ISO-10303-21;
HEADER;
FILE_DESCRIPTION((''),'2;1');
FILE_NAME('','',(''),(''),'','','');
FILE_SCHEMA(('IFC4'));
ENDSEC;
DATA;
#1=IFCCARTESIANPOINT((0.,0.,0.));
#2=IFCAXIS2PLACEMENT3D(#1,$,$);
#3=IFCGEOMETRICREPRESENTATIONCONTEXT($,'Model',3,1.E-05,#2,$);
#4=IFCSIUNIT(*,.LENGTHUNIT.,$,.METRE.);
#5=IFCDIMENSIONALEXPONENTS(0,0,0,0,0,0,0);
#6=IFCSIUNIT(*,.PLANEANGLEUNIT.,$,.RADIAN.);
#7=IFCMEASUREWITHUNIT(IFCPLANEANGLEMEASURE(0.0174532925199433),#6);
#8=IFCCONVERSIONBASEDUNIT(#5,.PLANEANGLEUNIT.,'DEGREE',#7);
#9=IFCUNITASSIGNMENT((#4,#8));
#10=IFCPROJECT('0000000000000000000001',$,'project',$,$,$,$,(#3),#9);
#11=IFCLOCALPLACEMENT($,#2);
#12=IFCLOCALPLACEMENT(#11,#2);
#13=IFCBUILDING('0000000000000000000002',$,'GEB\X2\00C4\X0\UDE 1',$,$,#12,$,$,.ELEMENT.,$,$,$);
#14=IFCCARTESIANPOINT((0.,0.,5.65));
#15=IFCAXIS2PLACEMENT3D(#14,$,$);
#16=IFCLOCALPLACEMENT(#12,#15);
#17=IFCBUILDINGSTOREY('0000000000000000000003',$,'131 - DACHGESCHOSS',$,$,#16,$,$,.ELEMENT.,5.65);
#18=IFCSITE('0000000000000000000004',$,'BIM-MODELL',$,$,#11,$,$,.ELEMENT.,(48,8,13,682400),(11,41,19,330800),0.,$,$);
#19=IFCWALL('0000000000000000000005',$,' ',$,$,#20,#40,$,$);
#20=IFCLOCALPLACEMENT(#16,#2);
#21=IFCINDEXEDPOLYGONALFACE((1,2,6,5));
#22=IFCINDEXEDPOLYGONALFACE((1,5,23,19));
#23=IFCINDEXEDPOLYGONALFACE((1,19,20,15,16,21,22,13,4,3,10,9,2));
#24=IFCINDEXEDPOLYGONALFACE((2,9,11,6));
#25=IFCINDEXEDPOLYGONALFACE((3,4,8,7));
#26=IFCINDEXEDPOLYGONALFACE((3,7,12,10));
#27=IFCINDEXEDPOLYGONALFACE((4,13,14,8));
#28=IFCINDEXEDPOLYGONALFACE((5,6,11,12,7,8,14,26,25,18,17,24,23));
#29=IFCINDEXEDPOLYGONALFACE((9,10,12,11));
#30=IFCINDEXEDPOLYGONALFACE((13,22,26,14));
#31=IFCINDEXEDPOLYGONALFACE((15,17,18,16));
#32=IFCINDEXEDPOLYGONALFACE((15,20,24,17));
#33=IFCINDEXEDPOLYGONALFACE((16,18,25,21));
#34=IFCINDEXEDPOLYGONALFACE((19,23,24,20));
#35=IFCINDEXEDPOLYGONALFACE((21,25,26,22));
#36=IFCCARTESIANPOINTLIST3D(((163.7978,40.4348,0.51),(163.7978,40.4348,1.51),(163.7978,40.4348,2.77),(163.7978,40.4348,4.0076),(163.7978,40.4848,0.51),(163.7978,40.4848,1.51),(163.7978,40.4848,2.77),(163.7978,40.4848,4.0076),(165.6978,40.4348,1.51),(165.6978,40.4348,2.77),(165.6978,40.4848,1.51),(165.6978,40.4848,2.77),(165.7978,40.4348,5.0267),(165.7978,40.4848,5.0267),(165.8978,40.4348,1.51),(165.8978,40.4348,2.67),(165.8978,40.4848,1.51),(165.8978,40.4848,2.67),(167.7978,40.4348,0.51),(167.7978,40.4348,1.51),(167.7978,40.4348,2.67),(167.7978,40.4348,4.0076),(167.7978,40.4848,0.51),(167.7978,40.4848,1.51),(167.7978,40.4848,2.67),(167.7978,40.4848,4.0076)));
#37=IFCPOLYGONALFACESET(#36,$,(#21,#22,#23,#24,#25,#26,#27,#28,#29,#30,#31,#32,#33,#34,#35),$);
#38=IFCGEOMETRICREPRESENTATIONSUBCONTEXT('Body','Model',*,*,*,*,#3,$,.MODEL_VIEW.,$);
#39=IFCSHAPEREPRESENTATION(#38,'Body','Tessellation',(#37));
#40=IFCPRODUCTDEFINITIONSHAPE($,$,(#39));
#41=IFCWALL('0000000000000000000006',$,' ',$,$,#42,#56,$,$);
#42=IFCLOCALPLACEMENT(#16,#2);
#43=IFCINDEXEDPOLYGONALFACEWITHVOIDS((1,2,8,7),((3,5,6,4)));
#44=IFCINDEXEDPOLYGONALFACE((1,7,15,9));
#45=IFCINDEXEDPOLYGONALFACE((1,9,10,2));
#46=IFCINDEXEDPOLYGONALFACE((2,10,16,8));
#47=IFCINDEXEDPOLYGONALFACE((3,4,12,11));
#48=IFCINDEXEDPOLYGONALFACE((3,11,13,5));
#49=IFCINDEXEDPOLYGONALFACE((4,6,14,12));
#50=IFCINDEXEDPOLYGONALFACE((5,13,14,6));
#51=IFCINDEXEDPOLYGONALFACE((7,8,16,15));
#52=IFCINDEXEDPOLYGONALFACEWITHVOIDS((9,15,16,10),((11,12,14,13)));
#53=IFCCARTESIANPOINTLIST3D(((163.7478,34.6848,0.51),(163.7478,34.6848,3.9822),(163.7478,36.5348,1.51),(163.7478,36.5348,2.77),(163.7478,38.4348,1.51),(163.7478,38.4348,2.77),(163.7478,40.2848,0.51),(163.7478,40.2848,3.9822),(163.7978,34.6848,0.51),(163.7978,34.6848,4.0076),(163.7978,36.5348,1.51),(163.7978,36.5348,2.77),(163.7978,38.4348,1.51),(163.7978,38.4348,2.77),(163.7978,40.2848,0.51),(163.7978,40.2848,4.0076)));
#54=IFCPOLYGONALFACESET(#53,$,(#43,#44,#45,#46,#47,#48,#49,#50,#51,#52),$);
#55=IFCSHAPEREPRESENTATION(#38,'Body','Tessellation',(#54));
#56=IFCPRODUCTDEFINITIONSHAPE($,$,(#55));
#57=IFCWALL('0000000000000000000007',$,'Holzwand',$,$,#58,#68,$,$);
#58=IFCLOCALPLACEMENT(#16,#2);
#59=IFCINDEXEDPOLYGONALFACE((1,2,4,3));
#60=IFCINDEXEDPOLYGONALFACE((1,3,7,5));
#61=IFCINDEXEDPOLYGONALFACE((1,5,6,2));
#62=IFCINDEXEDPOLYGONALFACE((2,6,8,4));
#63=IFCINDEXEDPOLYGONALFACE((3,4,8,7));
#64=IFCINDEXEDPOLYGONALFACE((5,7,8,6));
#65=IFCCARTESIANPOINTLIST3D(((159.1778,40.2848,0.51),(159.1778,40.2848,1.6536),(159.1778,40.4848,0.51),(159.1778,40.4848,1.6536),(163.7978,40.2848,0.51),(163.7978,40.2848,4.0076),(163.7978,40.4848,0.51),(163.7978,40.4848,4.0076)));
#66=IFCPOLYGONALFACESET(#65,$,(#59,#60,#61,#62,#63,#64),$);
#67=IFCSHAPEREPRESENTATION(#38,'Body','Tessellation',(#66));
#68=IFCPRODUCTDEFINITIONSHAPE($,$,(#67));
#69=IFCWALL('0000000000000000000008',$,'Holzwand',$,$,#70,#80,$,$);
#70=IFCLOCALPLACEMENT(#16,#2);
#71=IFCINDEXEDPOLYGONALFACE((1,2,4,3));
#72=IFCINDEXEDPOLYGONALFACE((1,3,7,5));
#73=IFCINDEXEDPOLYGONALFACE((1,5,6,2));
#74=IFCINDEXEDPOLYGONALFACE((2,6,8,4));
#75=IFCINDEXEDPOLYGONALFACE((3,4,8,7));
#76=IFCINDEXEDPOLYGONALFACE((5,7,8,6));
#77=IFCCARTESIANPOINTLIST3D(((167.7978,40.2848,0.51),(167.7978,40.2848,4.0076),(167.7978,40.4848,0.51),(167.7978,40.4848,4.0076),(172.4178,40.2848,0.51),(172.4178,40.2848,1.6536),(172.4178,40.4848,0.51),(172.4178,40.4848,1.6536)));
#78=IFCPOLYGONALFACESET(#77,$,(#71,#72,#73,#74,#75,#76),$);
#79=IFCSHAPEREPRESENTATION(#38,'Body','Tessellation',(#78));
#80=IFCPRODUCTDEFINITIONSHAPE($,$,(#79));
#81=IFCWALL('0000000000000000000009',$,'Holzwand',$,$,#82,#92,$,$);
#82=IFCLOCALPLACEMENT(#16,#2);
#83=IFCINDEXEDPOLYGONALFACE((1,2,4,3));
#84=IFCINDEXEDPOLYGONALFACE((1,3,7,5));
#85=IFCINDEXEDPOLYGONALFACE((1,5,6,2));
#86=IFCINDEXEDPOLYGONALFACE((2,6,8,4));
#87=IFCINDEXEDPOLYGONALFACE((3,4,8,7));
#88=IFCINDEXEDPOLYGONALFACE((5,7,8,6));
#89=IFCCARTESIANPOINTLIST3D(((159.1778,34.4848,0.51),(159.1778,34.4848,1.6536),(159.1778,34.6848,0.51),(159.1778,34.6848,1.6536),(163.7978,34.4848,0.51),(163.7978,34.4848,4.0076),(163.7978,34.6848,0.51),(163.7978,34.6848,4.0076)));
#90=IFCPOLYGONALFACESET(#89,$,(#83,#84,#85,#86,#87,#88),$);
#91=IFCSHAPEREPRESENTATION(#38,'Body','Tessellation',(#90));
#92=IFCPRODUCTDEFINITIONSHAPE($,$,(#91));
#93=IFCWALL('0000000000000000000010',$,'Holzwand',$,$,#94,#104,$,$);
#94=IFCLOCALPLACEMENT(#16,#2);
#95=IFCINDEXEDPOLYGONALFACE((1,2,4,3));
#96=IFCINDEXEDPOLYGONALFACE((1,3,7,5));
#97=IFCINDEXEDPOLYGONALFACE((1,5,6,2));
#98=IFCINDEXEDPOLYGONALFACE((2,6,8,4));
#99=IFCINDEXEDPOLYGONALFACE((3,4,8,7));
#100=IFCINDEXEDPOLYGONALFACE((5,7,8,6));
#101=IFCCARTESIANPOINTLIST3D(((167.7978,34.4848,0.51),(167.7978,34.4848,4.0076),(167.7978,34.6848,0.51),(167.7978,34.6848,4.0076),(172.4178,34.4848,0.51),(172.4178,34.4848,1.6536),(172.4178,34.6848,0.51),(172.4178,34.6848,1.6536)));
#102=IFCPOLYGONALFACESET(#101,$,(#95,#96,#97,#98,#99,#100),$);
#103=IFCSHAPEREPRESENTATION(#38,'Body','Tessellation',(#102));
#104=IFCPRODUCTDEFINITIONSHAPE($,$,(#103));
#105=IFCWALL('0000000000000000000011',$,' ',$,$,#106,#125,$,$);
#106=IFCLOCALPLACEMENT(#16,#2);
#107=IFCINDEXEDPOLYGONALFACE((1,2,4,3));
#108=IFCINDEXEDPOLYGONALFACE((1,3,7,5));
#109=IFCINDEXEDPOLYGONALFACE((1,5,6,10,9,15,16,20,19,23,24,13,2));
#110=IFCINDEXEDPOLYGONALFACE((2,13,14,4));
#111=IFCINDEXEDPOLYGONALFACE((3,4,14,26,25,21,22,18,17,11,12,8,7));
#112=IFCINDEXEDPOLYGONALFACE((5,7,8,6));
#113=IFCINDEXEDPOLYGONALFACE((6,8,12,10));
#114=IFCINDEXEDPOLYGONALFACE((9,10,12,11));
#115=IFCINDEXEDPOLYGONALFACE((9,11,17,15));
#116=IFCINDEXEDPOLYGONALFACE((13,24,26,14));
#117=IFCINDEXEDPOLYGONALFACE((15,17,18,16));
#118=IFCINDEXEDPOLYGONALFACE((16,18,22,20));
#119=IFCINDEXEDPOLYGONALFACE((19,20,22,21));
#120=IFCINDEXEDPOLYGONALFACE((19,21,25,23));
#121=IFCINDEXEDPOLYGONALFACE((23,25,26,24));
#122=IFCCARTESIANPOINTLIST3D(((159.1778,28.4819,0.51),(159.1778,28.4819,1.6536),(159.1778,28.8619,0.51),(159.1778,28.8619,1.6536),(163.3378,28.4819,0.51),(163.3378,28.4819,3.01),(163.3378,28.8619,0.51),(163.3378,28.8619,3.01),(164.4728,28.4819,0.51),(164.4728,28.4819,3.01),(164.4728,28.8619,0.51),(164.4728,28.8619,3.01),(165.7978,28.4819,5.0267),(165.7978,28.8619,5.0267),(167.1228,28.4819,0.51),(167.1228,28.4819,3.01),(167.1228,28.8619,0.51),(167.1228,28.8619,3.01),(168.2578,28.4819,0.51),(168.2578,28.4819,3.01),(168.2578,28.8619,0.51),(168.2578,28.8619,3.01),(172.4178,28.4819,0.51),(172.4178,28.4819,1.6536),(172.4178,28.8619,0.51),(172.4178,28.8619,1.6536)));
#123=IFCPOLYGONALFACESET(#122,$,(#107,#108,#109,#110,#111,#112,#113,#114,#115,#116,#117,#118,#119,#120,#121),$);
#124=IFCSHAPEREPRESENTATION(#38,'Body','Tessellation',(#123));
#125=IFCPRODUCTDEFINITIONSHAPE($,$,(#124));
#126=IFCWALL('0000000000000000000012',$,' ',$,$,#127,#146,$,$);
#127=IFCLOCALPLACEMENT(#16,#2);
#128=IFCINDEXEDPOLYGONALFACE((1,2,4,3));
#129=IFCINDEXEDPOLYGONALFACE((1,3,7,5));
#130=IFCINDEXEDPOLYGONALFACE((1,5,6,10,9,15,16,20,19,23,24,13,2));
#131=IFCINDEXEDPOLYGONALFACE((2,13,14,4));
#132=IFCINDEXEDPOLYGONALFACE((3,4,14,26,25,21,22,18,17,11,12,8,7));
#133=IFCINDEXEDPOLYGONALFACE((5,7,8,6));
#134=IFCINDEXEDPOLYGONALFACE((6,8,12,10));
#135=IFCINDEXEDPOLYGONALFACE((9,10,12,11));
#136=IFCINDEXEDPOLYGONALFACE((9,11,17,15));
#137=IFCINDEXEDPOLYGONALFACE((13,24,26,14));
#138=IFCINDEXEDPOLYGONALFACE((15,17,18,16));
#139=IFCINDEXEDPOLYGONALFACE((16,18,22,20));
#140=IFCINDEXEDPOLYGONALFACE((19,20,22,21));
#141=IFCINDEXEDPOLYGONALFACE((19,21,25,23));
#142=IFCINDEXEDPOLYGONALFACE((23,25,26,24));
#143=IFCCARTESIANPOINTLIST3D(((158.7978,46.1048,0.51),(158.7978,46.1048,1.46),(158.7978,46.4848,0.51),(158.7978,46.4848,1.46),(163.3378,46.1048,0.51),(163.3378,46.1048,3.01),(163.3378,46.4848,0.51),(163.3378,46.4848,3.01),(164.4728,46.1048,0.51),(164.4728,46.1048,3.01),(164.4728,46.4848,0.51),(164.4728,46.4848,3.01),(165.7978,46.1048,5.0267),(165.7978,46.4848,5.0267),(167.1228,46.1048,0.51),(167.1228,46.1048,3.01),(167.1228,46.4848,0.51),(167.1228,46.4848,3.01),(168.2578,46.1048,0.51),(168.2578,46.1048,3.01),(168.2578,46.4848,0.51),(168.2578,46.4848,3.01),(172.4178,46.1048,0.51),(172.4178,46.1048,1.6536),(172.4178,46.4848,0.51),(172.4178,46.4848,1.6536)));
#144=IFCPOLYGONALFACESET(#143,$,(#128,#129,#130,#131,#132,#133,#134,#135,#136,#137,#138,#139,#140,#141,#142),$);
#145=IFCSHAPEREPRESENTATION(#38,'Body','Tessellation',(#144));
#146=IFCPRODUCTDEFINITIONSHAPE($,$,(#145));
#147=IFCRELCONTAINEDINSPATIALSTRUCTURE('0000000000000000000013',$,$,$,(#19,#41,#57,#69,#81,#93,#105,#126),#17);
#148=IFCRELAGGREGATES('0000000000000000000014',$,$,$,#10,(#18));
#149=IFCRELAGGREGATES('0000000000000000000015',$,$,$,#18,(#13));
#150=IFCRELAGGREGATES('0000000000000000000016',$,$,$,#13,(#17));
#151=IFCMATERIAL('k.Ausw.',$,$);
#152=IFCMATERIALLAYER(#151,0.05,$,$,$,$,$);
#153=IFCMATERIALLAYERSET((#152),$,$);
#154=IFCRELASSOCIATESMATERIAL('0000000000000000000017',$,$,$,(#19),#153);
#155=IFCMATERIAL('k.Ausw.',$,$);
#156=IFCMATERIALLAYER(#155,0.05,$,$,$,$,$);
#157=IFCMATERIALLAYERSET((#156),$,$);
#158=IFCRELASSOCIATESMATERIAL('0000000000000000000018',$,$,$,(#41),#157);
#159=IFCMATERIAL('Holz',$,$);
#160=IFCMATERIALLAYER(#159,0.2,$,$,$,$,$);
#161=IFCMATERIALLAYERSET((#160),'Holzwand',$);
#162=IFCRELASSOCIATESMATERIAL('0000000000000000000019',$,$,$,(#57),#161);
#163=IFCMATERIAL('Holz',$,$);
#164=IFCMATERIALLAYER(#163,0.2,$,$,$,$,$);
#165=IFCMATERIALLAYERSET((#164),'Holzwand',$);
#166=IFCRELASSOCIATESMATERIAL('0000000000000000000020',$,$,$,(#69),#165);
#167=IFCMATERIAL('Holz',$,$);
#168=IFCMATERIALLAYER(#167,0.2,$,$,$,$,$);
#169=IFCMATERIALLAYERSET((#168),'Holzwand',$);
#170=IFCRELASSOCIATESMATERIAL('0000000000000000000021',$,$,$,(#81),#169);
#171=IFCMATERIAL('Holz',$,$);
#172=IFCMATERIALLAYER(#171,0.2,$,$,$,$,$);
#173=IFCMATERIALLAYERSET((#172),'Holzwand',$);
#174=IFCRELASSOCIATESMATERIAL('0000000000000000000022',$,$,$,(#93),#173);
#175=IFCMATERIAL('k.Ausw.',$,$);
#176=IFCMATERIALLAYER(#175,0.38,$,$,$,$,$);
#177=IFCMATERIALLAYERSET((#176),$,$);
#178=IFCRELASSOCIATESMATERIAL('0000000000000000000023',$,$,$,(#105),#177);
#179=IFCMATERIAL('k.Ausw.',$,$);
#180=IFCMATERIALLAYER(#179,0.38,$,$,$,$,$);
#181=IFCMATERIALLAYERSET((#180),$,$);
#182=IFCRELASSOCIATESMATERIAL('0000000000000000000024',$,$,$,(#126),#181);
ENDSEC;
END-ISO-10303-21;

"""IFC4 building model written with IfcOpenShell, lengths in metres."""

from ifc_helpers import new_model, entity, si_unit, converted_unit, frame, frame_2d, origin, origin_with_axes, place, context, subcontext, project, spatial, polyline, rectangle, outline, extrude, clip, halfspace, bounded_halfspace, material, layer, layer_set, layer_usage, element, save


model = new_model("IFC4")

# Units and contexts
model_context = context("Model", 3, precision=1e-05, world=origin())
body_context = subcontext(model_context, "Body", "Model", "MODEL_VIEW")
ifc_project = project(units=[si_unit("LENGTHUNIT", "METRE"), converted_unit("PLANEANGLEUNIT", "DEGREE", entity("IfcPlaneAngleMeasure", 0.0174532925199433), si_unit("PLANEANGLEUNIT", "RADIAN"), dimensions=[0, 0, 0, 0, 0, 0, 0])], contexts=[model_context])

# Site, building, storey
site_placement = place(None, origin())
site = spatial("IfcSite", under=ifc_project, at=site_placement, Name="BIM-MODELL", CompositionType="ELEMENT", RefLatitude=(48, 8, 13, 682400), RefLongitude=(11, 41, 19, 330800), RefElevation=0.0)
building_placement = place(site_placement, origin())
building = spatial("IfcBuilding", under=site, at=building_placement, Name="GEBÄUDE 1", CompositionType="ELEMENT")
storey_placement = place(building_placement, frame((0.0, 0.0, 5.65)))
storey = spatial("IfcBuildingStorey", under=building, at=storey_placement, Name="131 - DACHGESCHOSS", CompositionType="ELEMENT", Elevation=5.65)

# Wall, openings
ifc_material_1 = material(Name="k.Ausw.")
ifc_layer_1 = layer(ifc_material_1, 0.05)
ifc_layer_set_1 = layer_set([ifc_layer_1])
ifc_layer_usage_1 = layer_usage(ifc_layer_set_1, "AXIS2", "POSITIVE", 0.0)
wall_1_placement = place(storey_placement, frame((167.7978, 40.4848, 0.51), z_axis=(0.0, 0.0, 1.0), x_axis=(-1.0, 0.0, 0.0)))
wall_1 = element("IfcWall", 1, at=wall_1_placement, inside=storey, material=ifc_layer_usage_1, Name=" ", context=body_context, shape_type="Clipping", body=[
    clip(clip(extrude(rectangle(XDim=4.0, YDim=0.05, at=frame_2d((2.0, 0.025), x_axis=(1.0, 0.0))), origin_with_axes(), (0.0, 0.0, 1.0), 4.5167), bounded_halfspace(frame((1.0, 0.025, 4.0072), z_axis=(0.45399, 0.0, -0.891007), x_axis=(0.891007, 0.0, 0.45399)), True, origin_with_axes(), polyline([(0.0, 0.0), (2.0, 0.0), (2.0, 0.05), (0.0, 0.05), (0.0, 0.0)]))), bounded_halfspace(frame((3.0, 0.025, 4.0072), z_axis=(-0.45399, 0.0, -0.891007), x_axis=(-0.891007, 0.0, 0.45399)), True, origin_with_axes(), polyline([(4.0, 0.05), (2.0, 0.05), (2.0, 0.0), (4.0, 0.0), (4.0, 0.05)]))),
])
opening_1_placement = place(wall_1_placement, frame((2.1, 0.0, 1.0), z_axis=(0.0, 1.0, 0.0), x_axis=(0.0, 0.0, 1.0)))
element("IfcOpeningElement", 2, at=opening_1_placement, cuts=wall_1, ObjectType="Opening", context=body_context, shape_type="SweptSolid", body=[
    extrude(outline(polyline([(0.0, 1.9), (1.26, 1.9), (1.26, 0.0), (0.0, 0.0), (0.0, 1.9)])), origin_with_axes(), (0.0, 0.0, 1.0), 0.05),
])
opening_2_placement = place(wall_1_placement, frame((0.0, 0.0, 1.0), z_axis=(0.0, 1.0, 0.0), x_axis=(0.0, 0.0, 1.0)))
element("IfcOpeningElement", 3, at=opening_2_placement, cuts=wall_1, ObjectType="Opening", context=body_context, shape_type="SweptSolid", body=[
    extrude(outline(polyline([(0.0, 1.9), (1.16, 1.9), (1.16, 0.0), (0.0, 0.0), (0.0, 1.9)])), origin_with_axes(), (0.0, 0.0, 1.0), 0.05),
])

# Wall, opening
ifc_material_2 = material(Name="k.Ausw.")
ifc_layer_2 = layer(ifc_material_2, 0.05)
ifc_layer_set_2 = layer_set([ifc_layer_2])
ifc_layer_usage_2 = layer_usage(ifc_layer_set_2, "AXIS2", "POSITIVE", 0.0)
wall_2_placement = place(storey_placement, frame((163.7478, 40.2848, 0.51), z_axis=(0.0, 0.0, 1.0), x_axis=(0.0, -1.0, 0.0)))
wall_2 = element("IfcWall", 4, at=wall_2_placement, inside=storey, material=ifc_layer_usage_2, Name=" ", context=body_context, shape_type="Clipping", body=[
    clip(extrude(rectangle(XDim=5.6, YDim=0.05, at=frame_2d((2.8, 0.025), x_axis=(1.0, 0.0))), origin_with_axes(), (0.0, 0.0, 1.0), 3.4976), halfspace(frame((2.8, 0.025, 3.4849), z_axis=(0.0, 0.45399, -0.891007), x_axis=(1.0, 0.0, 0.0)), True)),
])
opening_3_placement = place(wall_2_placement, frame((1.85, 0.0, 1.0), z_axis=(0.0, 1.0, 0.0), x_axis=(0.0, 0.0, 1.0)))
element("IfcOpeningElement", 5, at=opening_3_placement, cuts=wall_2, ObjectType="Opening", context=body_context, shape_type="SweptSolid", body=[
    extrude(outline(polyline([(0.0, 1.9), (1.26, 1.9), (1.26, 0.0), (0.0, 0.0), (0.0, 1.9)])), origin_with_axes(), (0.0, 0.0, 1.0), 0.05),
])

# Walls
ifc_material_3 = material(Name="Holz")
ifc_layer_3 = layer(ifc_material_3, 0.2)
ifc_layer_set_3 = layer_set([ifc_layer_3], Name="Holzwand")
ifc_layer_usage_3 = layer_usage(ifc_layer_set_3, "AXIS2", "POSITIVE", 0.0)
wall_3_placement = place(storey_placement, frame((163.7978, 40.4848, 0.51), z_axis=(0.0, 0.0, 1.0), x_axis=(-1.0, 0.0, 0.0)))
element("IfcWall", 6, at=wall_3_placement, inside=storey, material=ifc_layer_usage_3, Name="Holzwand", context=body_context, shape_type="Clipping", body=[
    clip(extrude(rectangle(XDim=4.62, YDim=0.2, at=frame_2d((2.31, 0.1), x_axis=(1.0, 0.0))), origin_with_axes(), (0.0, 0.0, 1.0), 3.4976), halfspace(frame((2.31, 0.1, 2.3206), z_axis=(-0.45399, 0.0, -0.891007), x_axis=(0.891007, 0.0, -0.45399)), True)),
])
ifc_material_4 = material(Name="Holz")
ifc_layer_4 = layer(ifc_material_4, 0.2)
ifc_layer_set_4 = layer_set([ifc_layer_4], Name="Holzwand")
ifc_layer_usage_4 = layer_usage(ifc_layer_set_4, "AXIS2", "POSITIVE", 0.0)
wall_4_placement = place(storey_placement, frame((172.4178, 40.4848, 0.51), z_axis=(0.0, 0.0, 1.0), x_axis=(-1.0, 0.0, 0.0)))
element("IfcWall", 7, at=wall_4_placement, inside=storey, material=ifc_layer_usage_4, Name="Holzwand", context=body_context, shape_type="Clipping", body=[
    clip(extrude(rectangle(XDim=4.62, YDim=0.2, at=frame_2d((2.31, 0.1), x_axis=(1.0, 0.0))), origin_with_axes(), (0.0, 0.0, 1.0), 3.4976), halfspace(frame((2.31, 0.1, 2.3206), z_axis=(0.45399, 0.0, -0.891007), x_axis=(0.891007, 0.0, 0.45399)), True)),
])
ifc_material_5 = material(Name="Holz")
ifc_layer_5 = layer(ifc_material_5, 0.2)
ifc_layer_set_5 = layer_set([ifc_layer_5], Name="Holzwand")
ifc_layer_usage_5 = layer_usage(ifc_layer_set_5, "AXIS2", "POSITIVE", 0.0)
wall_5_placement = place(storey_placement, frame((159.1778, 34.4848, 0.51)))
element("IfcWall", 8, at=wall_5_placement, inside=storey, material=ifc_layer_usage_5, Name="Holzwand", context=body_context, shape_type="Clipping", body=[
    clip(extrude(rectangle(XDim=4.62, YDim=0.2, at=frame_2d((2.31, 0.1), x_axis=(1.0, 0.0))), origin_with_axes(), (0.0, 0.0, 1.0), 3.4976), halfspace(frame((2.31, 0.1, 2.3206), z_axis=(0.45399, 0.0, -0.891007), x_axis=(0.891007, 0.0, 0.45399)), True)),
])
ifc_material_6 = material(Name="Holz")
ifc_layer_6 = layer(ifc_material_6, 0.2)
ifc_layer_set_6 = layer_set([ifc_layer_6], Name="Holzwand")
ifc_layer_usage_6 = layer_usage(ifc_layer_set_6, "AXIS2", "POSITIVE", 0.0)
wall_6_placement = place(storey_placement, frame((167.7978, 34.4848, 0.51)))
element("IfcWall", 9, at=wall_6_placement, inside=storey, material=ifc_layer_usage_6, Name="Holzwand", context=body_context, shape_type="Clipping", body=[
    clip(extrude(rectangle(XDim=4.62, YDim=0.2, at=frame_2d((2.31, 0.1), x_axis=(1.0, 0.0))), origin_with_axes(), (0.0, 0.0, 1.0), 3.4976), halfspace(frame((2.31, 0.1, 2.3206), z_axis=(-0.45399, 0.0, -0.891007), x_axis=(0.891007, 0.0, -0.45399)), True)),
])

# Walls, openings
ifc_material_7 = material(Name="k.Ausw.")
ifc_layer_7 = layer(ifc_material_7, 0.38)
ifc_layer_set_7 = layer_set([ifc_layer_7])
ifc_layer_usage_7 = layer_usage(ifc_layer_set_7, "AXIS2", "POSITIVE", 0.0)
wall_7_placement = place(storey_placement, frame((159.1778, 28.4819, 0.51), z_axis=(0.0, 0.0, 1.0), x_axis=(1.0, 0.0, 0.0)))
wall_7 = element("IfcWall", 10, at=wall_7_placement, inside=storey, material=ifc_layer_usage_7, Name=" ", context=body_context, shape_type="Clipping", body=[
    clip(clip(extrude(rectangle(XDim=13.24, YDim=0.38, at=frame_2d((6.62, 0.19), x_axis=(1.0, 0.0))), origin_with_axes(), (0.0, 0.0, 1.0), 4.5167), bounded_halfspace(frame((9.93, 0.19, 2.8301), z_axis=(-0.45399, 0.0, -0.891007), x_axis=(-0.891007, 0.0, 0.45399)), True, origin_with_axes(), polyline([(13.24, 0.38), (6.62, 0.38), (6.62, 0.0), (13.24, 0.0), (13.24, 0.38)]))), bounded_halfspace(frame((3.31, 0.19, 2.8301), z_axis=(0.45399, 0.0, -0.891007), x_axis=(0.0, -1.0, 0.0)), True, origin_with_axes(), polyline([(0.0, 0.38), (0.0, 0.0), (6.62, 0.0), (6.62, 0.38), (0.0, 0.38)]))),
])
opening_4_placement = place(wall_7_placement, frame((9.08, 0.38, 0.0), z_axis=(0.0, -1.0, 0.0), x_axis=(0.0, 0.0, 1.0)))
element("IfcOpeningElement", 11, at=opening_4_placement, cuts=wall_7, ObjectType="Opening", context=body_context, shape_type="SweptSolid", body=[
    extrude(outline(polyline([(0.0, 1.135), (2.5, 1.135), (2.5, 0.0), (0.0, 0.0), (0.0, 1.135)])), origin_with_axes(), (0.0, 0.0, 1.0), 0.38),
])
opening_5_placement = place(wall_7_placement, frame((5.295, 0.38, 0.0), z_axis=(0.0, -1.0, 0.0), x_axis=(0.0, 0.0, 1.0)))
element("IfcOpeningElement", 12, at=opening_5_placement, cuts=wall_7, ObjectType="Opening", context=body_context, shape_type="SweptSolid", body=[
    extrude(outline(polyline([(0.0, 1.135), (2.5, 1.135), (2.5, 0.0), (0.0, 0.0), (0.0, 1.135)])), origin_with_axes(), (0.0, 0.0, 1.0), 0.38),
])
ifc_material_8 = material(Name="k.Ausw.")
ifc_layer_8 = layer(ifc_material_8, 0.38)
ifc_layer_set_8 = layer_set([ifc_layer_8])
ifc_layer_usage_8 = layer_usage(ifc_layer_set_8, "AXIS2", "POSITIVE", 0.0)
wall_8_placement = place(storey_placement, frame((172.4178, 46.4848, 0.51), z_axis=(0.0, 0.0, 1.0), x_axis=(-1.0, 0.0, 0.0)))
wall_8 = element("IfcWall", 13, at=wall_8_placement, inside=storey, material=ifc_layer_usage_8, Name=" ", context=body_context, shape_type="Clipping", body=[
    clip(clip(extrude(rectangle(XDim=13.62, YDim=0.38, at=frame_2d((6.81, 0.19), x_axis=(1.0, 0.0))), origin_with_axes(), (0.0, 0.0, 1.0), 4.5167), bounded_halfspace(frame((3.31, 0.19, 2.8301), z_axis=(0.45399, 0.0, -0.891007), x_axis=(0.0, -1.0, 0.0)), True, origin_with_axes(), polyline([(0.0, 0.38), (0.0, 0.0), (6.62, 0.0), (6.62, 0.38), (0.0, 0.38)]))), bounded_halfspace(frame((10.12, 0.19, 2.7333), z_axis=(-0.45399, 0.0, -0.891007), x_axis=(0.891007, 0.0, -0.45399)), True, origin_with_axes(), polyline([(6.62, 0.0), (13.62, 0.0), (13.62, 0.38), (6.62, 0.38), (6.62, 0.0)]))),
])
opening_6_placement = place(wall_8_placement, frame((5.295, 0.38, 0.0), z_axis=(0.0, -1.0, 0.0), x_axis=(0.0, 0.0, 1.0)))
element("IfcOpeningElement", 14, at=opening_6_placement, cuts=wall_8, ObjectType="Opening", context=body_context, shape_type="SweptSolid", body=[
    extrude(outline(polyline([(0.0, 1.135), (2.5, 1.135), (2.5, 0.0), (0.0, 0.0), (0.0, 1.135)])), origin_with_axes(), (0.0, 0.0, 1.0), 0.38),
])
opening_7_placement = place(wall_8_placement, frame((9.08, 0.38, 0.0), z_axis=(0.0, -1.0, 0.0), x_axis=(0.0, 0.0, 1.0)))
element("IfcOpeningElement", 15, at=opening_7_placement, cuts=wall_8, ObjectType="Opening", context=body_context, shape_type="SweptSolid", body=[
    extrude(outline(polyline([(0.0, 1.135), (2.5, 1.135), (2.5, 0.0), (0.0, 0.0), (0.0, 1.135)])), origin_with_axes(), (0.0, 0.0, 1.0), 0.38),
])

save(model, "model.ifc")
